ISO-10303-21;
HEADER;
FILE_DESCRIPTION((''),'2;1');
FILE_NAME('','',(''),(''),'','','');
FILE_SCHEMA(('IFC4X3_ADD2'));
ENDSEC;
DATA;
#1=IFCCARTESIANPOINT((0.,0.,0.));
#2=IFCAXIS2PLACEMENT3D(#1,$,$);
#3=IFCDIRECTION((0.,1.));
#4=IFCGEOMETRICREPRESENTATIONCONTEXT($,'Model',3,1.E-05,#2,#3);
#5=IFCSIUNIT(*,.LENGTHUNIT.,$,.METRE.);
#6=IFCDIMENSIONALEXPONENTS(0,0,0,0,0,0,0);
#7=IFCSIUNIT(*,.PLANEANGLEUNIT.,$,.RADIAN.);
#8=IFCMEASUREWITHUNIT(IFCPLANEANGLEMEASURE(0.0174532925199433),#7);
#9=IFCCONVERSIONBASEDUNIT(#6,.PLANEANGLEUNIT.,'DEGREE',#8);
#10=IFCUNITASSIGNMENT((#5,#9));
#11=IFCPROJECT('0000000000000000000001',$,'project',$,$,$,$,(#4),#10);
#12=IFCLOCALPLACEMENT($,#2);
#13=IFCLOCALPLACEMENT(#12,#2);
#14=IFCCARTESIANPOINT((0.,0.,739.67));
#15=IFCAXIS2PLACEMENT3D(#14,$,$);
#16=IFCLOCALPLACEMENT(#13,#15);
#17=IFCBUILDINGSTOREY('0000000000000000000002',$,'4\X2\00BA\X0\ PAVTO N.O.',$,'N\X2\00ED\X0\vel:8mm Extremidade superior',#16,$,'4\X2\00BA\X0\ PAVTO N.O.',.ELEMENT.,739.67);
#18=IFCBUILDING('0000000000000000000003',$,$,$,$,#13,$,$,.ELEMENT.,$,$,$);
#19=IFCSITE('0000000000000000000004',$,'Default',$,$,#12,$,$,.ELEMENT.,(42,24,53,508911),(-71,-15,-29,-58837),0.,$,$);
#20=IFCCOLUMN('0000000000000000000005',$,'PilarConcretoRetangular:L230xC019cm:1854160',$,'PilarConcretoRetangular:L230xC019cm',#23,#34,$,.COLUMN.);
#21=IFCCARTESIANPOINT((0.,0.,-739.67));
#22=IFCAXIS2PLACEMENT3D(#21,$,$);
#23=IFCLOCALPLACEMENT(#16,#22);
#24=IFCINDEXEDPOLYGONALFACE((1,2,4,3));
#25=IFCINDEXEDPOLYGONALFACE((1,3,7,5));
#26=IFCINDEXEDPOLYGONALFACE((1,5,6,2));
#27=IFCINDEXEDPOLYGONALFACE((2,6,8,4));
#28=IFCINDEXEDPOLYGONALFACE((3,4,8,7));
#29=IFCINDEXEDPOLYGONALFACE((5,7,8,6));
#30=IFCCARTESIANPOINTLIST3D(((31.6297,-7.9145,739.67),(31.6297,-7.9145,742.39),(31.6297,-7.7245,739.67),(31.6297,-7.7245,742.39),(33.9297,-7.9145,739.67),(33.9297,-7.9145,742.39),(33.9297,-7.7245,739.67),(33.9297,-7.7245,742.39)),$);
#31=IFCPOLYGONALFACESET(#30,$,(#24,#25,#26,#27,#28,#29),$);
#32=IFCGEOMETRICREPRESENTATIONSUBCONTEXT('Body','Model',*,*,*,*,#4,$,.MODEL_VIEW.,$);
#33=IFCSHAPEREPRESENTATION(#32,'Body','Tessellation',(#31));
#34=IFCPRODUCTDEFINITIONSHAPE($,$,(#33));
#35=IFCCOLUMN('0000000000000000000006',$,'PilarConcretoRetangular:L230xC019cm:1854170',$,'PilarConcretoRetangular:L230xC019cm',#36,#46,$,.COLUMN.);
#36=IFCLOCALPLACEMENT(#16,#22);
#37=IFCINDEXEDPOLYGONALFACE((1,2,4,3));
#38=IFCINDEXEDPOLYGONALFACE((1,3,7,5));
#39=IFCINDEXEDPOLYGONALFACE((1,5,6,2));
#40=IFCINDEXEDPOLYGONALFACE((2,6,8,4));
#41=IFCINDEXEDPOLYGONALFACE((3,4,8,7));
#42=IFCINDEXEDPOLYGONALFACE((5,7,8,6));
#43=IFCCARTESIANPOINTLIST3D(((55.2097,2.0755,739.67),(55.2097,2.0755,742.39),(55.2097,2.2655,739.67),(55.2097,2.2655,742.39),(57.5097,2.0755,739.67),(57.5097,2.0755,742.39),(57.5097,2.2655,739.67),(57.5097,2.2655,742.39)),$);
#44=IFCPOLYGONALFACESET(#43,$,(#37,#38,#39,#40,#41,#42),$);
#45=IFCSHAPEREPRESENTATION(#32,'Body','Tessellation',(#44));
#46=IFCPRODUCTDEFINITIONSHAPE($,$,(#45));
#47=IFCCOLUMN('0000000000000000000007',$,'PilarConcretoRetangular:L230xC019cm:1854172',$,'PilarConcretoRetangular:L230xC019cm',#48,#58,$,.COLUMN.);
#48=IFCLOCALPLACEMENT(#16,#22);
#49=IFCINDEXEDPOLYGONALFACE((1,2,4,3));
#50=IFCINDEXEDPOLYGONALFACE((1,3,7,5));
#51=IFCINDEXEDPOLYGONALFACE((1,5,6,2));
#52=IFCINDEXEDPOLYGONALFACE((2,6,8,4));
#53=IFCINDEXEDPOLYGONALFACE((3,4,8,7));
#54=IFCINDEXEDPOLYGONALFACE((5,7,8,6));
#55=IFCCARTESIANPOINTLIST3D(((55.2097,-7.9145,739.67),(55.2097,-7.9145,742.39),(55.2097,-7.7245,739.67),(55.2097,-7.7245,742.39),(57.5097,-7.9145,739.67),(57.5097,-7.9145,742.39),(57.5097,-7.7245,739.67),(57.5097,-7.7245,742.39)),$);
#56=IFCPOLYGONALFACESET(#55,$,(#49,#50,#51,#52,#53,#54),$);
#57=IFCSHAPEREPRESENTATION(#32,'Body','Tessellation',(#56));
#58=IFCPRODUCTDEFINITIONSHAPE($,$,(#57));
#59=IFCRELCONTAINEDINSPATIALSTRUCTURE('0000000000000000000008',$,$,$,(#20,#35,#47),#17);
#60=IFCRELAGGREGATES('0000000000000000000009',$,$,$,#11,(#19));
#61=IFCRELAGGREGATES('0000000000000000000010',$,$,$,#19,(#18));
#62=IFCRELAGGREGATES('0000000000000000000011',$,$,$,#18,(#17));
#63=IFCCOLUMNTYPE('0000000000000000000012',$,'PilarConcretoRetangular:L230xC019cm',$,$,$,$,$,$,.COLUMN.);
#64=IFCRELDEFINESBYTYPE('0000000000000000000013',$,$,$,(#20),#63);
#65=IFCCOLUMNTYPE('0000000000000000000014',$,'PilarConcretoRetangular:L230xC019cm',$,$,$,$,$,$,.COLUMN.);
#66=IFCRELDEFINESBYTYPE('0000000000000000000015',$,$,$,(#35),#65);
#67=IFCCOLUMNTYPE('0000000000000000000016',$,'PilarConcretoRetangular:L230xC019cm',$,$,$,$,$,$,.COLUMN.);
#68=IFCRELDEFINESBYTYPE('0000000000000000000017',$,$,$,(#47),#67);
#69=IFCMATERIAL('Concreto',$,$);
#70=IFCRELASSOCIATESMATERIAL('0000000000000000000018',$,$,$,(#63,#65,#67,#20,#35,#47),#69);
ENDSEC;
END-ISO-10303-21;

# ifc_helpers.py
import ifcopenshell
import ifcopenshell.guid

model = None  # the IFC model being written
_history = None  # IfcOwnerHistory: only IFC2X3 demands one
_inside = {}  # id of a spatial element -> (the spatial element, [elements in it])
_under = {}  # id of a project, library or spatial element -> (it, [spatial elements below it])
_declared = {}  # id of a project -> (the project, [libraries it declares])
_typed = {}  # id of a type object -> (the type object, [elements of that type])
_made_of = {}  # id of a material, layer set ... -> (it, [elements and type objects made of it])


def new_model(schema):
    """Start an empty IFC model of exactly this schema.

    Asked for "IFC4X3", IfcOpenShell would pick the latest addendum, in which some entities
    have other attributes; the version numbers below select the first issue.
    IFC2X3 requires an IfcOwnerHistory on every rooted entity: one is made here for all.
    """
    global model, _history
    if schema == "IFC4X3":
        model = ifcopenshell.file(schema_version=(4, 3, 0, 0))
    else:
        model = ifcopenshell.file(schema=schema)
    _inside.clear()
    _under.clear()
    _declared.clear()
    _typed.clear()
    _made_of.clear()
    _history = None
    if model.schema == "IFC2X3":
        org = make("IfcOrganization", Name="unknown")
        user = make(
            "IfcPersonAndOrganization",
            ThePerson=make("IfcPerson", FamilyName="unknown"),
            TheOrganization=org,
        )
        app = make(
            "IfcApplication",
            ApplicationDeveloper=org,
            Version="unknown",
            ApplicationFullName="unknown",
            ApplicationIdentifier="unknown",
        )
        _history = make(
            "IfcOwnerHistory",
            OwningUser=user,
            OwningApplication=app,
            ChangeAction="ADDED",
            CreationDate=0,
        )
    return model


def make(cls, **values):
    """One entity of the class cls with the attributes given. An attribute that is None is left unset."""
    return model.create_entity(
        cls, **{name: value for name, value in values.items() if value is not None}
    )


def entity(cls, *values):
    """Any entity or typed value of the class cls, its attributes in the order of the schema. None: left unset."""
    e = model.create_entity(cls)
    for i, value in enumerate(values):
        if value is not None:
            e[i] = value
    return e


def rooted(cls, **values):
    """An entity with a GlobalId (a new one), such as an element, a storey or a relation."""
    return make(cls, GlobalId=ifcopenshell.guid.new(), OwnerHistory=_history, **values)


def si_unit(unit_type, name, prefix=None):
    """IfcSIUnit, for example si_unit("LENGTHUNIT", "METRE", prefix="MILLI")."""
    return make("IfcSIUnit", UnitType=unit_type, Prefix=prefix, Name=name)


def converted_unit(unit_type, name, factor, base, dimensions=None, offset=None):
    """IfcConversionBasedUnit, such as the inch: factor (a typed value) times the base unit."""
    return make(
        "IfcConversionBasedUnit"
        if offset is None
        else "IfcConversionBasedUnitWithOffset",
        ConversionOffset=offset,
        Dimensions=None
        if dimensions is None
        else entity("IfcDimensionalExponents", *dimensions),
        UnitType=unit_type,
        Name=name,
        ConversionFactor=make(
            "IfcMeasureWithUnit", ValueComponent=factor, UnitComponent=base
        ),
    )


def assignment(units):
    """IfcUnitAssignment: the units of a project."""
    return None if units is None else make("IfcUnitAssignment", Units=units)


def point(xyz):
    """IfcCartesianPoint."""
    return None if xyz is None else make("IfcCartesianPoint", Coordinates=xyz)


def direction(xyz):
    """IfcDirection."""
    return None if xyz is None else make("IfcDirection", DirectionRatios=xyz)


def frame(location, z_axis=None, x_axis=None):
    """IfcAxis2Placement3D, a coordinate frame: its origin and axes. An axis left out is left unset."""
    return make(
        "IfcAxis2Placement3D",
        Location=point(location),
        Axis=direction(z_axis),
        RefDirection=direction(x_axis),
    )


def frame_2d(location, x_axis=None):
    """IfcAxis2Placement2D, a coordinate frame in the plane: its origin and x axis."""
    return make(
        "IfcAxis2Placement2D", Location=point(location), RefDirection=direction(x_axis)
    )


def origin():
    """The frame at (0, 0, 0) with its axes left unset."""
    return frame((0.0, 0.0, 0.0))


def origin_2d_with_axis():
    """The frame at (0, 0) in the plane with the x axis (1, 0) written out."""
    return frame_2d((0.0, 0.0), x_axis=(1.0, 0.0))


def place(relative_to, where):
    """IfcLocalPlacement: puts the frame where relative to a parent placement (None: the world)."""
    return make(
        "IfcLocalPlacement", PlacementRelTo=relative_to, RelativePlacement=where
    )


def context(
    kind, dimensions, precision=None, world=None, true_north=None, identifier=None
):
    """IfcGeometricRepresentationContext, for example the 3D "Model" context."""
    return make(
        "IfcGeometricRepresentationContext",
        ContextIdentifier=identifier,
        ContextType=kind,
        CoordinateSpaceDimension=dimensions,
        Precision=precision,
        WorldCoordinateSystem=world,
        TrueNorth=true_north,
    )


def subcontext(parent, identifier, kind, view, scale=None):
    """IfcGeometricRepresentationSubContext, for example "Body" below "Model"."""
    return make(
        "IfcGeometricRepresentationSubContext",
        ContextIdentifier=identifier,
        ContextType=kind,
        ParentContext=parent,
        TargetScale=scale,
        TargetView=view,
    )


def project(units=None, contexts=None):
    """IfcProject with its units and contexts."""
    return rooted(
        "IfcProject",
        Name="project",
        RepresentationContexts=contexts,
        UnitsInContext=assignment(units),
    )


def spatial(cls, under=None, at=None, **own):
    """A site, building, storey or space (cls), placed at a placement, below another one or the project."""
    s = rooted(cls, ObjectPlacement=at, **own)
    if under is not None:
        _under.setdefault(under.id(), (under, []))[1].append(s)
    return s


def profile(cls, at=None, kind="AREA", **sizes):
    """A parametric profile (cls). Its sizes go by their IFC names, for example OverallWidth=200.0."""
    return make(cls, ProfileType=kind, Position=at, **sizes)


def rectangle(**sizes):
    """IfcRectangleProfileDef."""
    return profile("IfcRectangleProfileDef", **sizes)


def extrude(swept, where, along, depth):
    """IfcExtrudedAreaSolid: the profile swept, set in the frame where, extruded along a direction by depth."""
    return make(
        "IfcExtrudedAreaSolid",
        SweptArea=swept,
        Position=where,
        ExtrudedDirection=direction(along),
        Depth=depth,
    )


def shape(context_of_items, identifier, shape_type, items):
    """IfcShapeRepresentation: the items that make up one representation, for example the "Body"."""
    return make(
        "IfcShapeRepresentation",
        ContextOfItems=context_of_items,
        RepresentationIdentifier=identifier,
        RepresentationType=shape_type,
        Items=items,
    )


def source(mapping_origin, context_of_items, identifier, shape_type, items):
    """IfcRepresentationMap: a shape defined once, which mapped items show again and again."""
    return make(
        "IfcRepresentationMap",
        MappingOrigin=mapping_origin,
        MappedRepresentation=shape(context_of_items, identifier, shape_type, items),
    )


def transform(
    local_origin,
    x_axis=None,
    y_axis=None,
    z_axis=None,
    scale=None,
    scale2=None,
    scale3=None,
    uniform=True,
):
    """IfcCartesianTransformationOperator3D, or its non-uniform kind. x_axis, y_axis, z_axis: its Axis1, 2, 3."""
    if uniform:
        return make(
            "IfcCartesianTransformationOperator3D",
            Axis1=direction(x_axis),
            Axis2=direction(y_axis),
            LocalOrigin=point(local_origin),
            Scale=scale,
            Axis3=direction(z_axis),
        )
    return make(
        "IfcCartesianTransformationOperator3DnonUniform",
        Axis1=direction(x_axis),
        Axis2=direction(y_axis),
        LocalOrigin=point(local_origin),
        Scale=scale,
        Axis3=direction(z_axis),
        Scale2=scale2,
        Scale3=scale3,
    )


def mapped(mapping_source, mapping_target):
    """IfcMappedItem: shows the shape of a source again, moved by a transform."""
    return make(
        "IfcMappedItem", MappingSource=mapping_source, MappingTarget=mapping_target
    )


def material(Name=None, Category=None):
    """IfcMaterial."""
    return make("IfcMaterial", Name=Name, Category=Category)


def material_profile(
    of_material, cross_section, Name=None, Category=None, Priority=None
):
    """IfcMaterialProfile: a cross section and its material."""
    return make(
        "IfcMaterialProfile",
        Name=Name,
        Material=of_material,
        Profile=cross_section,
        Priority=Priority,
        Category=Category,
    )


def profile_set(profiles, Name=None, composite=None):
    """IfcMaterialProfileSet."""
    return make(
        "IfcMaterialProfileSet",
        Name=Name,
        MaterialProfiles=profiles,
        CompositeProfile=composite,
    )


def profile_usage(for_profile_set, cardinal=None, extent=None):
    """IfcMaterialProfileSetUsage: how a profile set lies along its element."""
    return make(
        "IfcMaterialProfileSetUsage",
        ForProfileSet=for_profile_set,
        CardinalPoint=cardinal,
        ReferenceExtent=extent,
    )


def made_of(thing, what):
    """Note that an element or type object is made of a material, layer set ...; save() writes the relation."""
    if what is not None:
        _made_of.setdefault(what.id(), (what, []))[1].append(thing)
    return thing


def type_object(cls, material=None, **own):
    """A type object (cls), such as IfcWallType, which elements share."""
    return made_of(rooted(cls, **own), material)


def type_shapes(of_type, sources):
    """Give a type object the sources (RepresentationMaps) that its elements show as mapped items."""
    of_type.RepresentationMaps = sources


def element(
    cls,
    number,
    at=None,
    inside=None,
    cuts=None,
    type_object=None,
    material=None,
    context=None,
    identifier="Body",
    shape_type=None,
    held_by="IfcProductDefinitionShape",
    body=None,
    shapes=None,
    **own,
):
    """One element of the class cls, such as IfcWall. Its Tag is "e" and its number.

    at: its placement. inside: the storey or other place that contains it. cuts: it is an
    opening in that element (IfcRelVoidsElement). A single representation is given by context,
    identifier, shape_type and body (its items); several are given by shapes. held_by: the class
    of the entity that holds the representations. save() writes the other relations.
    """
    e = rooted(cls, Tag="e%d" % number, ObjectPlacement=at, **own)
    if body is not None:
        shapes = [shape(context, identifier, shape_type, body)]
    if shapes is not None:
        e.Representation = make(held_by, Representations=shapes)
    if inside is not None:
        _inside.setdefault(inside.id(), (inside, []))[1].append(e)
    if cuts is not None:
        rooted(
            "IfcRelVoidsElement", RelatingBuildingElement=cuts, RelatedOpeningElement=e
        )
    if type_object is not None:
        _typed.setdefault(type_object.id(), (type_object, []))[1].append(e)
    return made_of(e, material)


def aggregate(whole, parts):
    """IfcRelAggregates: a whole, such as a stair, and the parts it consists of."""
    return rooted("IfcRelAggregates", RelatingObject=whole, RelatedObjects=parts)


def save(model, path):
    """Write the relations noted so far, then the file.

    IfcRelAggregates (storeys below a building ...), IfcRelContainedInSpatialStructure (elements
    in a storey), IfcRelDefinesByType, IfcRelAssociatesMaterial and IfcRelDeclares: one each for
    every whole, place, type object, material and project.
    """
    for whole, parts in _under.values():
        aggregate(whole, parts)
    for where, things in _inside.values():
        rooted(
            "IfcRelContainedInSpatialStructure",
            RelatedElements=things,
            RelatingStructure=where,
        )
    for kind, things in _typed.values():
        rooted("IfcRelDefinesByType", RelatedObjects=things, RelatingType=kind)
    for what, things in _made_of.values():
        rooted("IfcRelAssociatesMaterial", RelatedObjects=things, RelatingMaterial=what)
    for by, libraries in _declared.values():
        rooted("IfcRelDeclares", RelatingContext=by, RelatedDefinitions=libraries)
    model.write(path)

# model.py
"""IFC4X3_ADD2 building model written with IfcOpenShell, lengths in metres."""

from ifc_helpers import new_model, entity, si_unit, converted_unit, direction, frame, frame_2d, origin, origin_2d_with_axis, place, context, subcontext, project, spatial, rectangle, extrude, source, transform, mapped, material, material_profile, profile_set, profile_usage, type_object, type_shapes, element, save


model = new_model("IFC4X3_ADD2")

# Units and contexts
model_context = context("Model", 3, precision=1e-05, world=origin(), true_north=direction((0.0, 1.0)))
body_context = subcontext(model_context, "Body", "Model", "MODEL_VIEW")
ifc_project = project(units=[si_unit("LENGTHUNIT", "METRE"), converted_unit("PLANEANGLEUNIT", "DEGREE", entity("IfcPlaneAngleMeasure", 0.0174532925199433), si_unit("PLANEANGLEUNIT", "RADIAN"), dimensions=[0, 0, 0, 0, 0, 0, 0])], contexts=[model_context])

# Site, building, storey
site_placement = place(None, origin())
site = spatial("IfcSite", under=ifc_project, at=site_placement, Name="Default", CompositionType="ELEMENT", RefLatitude=(42, 24, 53, 508911), RefLongitude=(-71, -15, -29, -58837), RefElevation=0.0)
building_placement = place(site_placement, origin())
building = spatial("IfcBuilding", under=site, at=building_placement, CompositionType="ELEMENT")
storey_placement = place(building_placement, frame((0.0, 0.0, 739.67)))
storey = spatial("IfcBuildingStorey", under=building, at=storey_placement, Name="4º PAVTO N.O.", ObjectType="Nível:8mm Extremidade superior", LongName="4º PAVTO N.O.", CompositionType="ELEMENT", Elevation=739.67)

# Columns
ifc_material = material(Name="Concreto")
ifc_material_profile_1 = material_profile(ifc_material, rectangle(XDim=2.3, YDim=0.19, at=frame_2d((0.192, 0.019), x_axis=(1.0, 0.0))), Name="L230xC019cm")
ifc_profile_set_1 = profile_set([ifc_material_profile_1], Name="L230xC019cm")
ifc_profile_usage_1 = profile_usage(ifc_profile_set_1)
column_type_1 = type_object("IfcColumnType", Name="PilarConcretoRetangular:L230xC019cm", PredefinedType="COLUMN", material=ifc_profile_set_1)
shared_shape_1 = source(origin(), body_context, "Body", "SweptSolid", [
    extrude(rectangle(XDim=2.3, YDim=0.19, at=frame_2d((0.0, 0.0), x_axis=(1.0, 0.0))), frame((32.7797, -7.8195, 739.67)), (0.0, 0.0, 1.0), 2.72),
])
type_shapes(column_type_1, [shared_shape_1])
column_1_placement = place(storey_placement, frame((0.0, 0.0, -739.67)))
element("IfcColumn", 1, at=column_1_placement, inside=storey, type_object=column_type_1, material=ifc_profile_usage_1, Name="PilarConcretoRetangular:L230xC019cm:1854160", ObjectType="PilarConcretoRetangular:L230xC019cm", PredefinedType="COLUMN", context=body_context, shape_type="MappedRepresentation", body=[
    mapped(shared_shape_1, transform((0.0, 0.0, 0.0), scale=1.0)),
])
column_type_2 = type_object("IfcColumnType", Name="PilarConcretoRetangular:L230xC019cm", PredefinedType="COLUMN", material=ifc_profile_set_1)
shared_shape_2 = source(origin(), body_context, "Body", "SweptSolid", [
    extrude(rectangle(XDim=2.3, YDim=0.19, at=origin_2d_with_axis()), frame((56.3597, 2.1705, 739.67), z_axis=(0.0, 0.0, 1.0), x_axis=(-1.0, 0.0, 0.0)), (0.0, 0.0, 1.0), 2.72),
])
type_shapes(column_type_2, [shared_shape_2])
column_2_placement = place(storey_placement, frame((0.0, 0.0, -739.67)))
element("IfcColumn", 2, at=column_2_placement, inside=storey, type_object=column_type_2, material=ifc_profile_usage_1, Name="PilarConcretoRetangular:L230xC019cm:1854170", ObjectType="PilarConcretoRetangular:L230xC019cm", PredefinedType="COLUMN", context=body_context, shape_type="MappedRepresentation", body=[
    mapped(shared_shape_2, transform((0.0, 0.0, 0.0), scale=1.0)),
])
column_type_3 = type_object("IfcColumnType", Name="PilarConcretoRetangular:L230xC019cm", PredefinedType="COLUMN", material=ifc_profile_set_1)
shared_shape_3 = source(origin(), body_context, "Body", "SweptSolid", [
    extrude(rectangle(XDim=2.3, YDim=0.19, at=origin_2d_with_axis()), frame((56.3597, -7.8195, 739.67), z_axis=(0.0, 0.0, 1.0), x_axis=(-1.0, 0.0, 0.0)), (0.0, 0.0, 1.0), 2.72),
])
type_shapes(column_type_3, [shared_shape_3])
column_3_placement = place(storey_placement, frame((0.0, 0.0, -739.67)))
element("IfcColumn", 3, at=column_3_placement, inside=storey, type_object=column_type_3, material=ifc_profile_usage_1, Name="PilarConcretoRetangular:L230xC019cm:1854172", ObjectType="PilarConcretoRetangular:L230xC019cm", PredefinedType="COLUMN", context=body_context, shape_type="MappedRepresentation", body=[
    mapped(shared_shape_3, transform((0.0, 0.0, 0.0), scale=1.0)),
])

save(model, "model.ifc")
